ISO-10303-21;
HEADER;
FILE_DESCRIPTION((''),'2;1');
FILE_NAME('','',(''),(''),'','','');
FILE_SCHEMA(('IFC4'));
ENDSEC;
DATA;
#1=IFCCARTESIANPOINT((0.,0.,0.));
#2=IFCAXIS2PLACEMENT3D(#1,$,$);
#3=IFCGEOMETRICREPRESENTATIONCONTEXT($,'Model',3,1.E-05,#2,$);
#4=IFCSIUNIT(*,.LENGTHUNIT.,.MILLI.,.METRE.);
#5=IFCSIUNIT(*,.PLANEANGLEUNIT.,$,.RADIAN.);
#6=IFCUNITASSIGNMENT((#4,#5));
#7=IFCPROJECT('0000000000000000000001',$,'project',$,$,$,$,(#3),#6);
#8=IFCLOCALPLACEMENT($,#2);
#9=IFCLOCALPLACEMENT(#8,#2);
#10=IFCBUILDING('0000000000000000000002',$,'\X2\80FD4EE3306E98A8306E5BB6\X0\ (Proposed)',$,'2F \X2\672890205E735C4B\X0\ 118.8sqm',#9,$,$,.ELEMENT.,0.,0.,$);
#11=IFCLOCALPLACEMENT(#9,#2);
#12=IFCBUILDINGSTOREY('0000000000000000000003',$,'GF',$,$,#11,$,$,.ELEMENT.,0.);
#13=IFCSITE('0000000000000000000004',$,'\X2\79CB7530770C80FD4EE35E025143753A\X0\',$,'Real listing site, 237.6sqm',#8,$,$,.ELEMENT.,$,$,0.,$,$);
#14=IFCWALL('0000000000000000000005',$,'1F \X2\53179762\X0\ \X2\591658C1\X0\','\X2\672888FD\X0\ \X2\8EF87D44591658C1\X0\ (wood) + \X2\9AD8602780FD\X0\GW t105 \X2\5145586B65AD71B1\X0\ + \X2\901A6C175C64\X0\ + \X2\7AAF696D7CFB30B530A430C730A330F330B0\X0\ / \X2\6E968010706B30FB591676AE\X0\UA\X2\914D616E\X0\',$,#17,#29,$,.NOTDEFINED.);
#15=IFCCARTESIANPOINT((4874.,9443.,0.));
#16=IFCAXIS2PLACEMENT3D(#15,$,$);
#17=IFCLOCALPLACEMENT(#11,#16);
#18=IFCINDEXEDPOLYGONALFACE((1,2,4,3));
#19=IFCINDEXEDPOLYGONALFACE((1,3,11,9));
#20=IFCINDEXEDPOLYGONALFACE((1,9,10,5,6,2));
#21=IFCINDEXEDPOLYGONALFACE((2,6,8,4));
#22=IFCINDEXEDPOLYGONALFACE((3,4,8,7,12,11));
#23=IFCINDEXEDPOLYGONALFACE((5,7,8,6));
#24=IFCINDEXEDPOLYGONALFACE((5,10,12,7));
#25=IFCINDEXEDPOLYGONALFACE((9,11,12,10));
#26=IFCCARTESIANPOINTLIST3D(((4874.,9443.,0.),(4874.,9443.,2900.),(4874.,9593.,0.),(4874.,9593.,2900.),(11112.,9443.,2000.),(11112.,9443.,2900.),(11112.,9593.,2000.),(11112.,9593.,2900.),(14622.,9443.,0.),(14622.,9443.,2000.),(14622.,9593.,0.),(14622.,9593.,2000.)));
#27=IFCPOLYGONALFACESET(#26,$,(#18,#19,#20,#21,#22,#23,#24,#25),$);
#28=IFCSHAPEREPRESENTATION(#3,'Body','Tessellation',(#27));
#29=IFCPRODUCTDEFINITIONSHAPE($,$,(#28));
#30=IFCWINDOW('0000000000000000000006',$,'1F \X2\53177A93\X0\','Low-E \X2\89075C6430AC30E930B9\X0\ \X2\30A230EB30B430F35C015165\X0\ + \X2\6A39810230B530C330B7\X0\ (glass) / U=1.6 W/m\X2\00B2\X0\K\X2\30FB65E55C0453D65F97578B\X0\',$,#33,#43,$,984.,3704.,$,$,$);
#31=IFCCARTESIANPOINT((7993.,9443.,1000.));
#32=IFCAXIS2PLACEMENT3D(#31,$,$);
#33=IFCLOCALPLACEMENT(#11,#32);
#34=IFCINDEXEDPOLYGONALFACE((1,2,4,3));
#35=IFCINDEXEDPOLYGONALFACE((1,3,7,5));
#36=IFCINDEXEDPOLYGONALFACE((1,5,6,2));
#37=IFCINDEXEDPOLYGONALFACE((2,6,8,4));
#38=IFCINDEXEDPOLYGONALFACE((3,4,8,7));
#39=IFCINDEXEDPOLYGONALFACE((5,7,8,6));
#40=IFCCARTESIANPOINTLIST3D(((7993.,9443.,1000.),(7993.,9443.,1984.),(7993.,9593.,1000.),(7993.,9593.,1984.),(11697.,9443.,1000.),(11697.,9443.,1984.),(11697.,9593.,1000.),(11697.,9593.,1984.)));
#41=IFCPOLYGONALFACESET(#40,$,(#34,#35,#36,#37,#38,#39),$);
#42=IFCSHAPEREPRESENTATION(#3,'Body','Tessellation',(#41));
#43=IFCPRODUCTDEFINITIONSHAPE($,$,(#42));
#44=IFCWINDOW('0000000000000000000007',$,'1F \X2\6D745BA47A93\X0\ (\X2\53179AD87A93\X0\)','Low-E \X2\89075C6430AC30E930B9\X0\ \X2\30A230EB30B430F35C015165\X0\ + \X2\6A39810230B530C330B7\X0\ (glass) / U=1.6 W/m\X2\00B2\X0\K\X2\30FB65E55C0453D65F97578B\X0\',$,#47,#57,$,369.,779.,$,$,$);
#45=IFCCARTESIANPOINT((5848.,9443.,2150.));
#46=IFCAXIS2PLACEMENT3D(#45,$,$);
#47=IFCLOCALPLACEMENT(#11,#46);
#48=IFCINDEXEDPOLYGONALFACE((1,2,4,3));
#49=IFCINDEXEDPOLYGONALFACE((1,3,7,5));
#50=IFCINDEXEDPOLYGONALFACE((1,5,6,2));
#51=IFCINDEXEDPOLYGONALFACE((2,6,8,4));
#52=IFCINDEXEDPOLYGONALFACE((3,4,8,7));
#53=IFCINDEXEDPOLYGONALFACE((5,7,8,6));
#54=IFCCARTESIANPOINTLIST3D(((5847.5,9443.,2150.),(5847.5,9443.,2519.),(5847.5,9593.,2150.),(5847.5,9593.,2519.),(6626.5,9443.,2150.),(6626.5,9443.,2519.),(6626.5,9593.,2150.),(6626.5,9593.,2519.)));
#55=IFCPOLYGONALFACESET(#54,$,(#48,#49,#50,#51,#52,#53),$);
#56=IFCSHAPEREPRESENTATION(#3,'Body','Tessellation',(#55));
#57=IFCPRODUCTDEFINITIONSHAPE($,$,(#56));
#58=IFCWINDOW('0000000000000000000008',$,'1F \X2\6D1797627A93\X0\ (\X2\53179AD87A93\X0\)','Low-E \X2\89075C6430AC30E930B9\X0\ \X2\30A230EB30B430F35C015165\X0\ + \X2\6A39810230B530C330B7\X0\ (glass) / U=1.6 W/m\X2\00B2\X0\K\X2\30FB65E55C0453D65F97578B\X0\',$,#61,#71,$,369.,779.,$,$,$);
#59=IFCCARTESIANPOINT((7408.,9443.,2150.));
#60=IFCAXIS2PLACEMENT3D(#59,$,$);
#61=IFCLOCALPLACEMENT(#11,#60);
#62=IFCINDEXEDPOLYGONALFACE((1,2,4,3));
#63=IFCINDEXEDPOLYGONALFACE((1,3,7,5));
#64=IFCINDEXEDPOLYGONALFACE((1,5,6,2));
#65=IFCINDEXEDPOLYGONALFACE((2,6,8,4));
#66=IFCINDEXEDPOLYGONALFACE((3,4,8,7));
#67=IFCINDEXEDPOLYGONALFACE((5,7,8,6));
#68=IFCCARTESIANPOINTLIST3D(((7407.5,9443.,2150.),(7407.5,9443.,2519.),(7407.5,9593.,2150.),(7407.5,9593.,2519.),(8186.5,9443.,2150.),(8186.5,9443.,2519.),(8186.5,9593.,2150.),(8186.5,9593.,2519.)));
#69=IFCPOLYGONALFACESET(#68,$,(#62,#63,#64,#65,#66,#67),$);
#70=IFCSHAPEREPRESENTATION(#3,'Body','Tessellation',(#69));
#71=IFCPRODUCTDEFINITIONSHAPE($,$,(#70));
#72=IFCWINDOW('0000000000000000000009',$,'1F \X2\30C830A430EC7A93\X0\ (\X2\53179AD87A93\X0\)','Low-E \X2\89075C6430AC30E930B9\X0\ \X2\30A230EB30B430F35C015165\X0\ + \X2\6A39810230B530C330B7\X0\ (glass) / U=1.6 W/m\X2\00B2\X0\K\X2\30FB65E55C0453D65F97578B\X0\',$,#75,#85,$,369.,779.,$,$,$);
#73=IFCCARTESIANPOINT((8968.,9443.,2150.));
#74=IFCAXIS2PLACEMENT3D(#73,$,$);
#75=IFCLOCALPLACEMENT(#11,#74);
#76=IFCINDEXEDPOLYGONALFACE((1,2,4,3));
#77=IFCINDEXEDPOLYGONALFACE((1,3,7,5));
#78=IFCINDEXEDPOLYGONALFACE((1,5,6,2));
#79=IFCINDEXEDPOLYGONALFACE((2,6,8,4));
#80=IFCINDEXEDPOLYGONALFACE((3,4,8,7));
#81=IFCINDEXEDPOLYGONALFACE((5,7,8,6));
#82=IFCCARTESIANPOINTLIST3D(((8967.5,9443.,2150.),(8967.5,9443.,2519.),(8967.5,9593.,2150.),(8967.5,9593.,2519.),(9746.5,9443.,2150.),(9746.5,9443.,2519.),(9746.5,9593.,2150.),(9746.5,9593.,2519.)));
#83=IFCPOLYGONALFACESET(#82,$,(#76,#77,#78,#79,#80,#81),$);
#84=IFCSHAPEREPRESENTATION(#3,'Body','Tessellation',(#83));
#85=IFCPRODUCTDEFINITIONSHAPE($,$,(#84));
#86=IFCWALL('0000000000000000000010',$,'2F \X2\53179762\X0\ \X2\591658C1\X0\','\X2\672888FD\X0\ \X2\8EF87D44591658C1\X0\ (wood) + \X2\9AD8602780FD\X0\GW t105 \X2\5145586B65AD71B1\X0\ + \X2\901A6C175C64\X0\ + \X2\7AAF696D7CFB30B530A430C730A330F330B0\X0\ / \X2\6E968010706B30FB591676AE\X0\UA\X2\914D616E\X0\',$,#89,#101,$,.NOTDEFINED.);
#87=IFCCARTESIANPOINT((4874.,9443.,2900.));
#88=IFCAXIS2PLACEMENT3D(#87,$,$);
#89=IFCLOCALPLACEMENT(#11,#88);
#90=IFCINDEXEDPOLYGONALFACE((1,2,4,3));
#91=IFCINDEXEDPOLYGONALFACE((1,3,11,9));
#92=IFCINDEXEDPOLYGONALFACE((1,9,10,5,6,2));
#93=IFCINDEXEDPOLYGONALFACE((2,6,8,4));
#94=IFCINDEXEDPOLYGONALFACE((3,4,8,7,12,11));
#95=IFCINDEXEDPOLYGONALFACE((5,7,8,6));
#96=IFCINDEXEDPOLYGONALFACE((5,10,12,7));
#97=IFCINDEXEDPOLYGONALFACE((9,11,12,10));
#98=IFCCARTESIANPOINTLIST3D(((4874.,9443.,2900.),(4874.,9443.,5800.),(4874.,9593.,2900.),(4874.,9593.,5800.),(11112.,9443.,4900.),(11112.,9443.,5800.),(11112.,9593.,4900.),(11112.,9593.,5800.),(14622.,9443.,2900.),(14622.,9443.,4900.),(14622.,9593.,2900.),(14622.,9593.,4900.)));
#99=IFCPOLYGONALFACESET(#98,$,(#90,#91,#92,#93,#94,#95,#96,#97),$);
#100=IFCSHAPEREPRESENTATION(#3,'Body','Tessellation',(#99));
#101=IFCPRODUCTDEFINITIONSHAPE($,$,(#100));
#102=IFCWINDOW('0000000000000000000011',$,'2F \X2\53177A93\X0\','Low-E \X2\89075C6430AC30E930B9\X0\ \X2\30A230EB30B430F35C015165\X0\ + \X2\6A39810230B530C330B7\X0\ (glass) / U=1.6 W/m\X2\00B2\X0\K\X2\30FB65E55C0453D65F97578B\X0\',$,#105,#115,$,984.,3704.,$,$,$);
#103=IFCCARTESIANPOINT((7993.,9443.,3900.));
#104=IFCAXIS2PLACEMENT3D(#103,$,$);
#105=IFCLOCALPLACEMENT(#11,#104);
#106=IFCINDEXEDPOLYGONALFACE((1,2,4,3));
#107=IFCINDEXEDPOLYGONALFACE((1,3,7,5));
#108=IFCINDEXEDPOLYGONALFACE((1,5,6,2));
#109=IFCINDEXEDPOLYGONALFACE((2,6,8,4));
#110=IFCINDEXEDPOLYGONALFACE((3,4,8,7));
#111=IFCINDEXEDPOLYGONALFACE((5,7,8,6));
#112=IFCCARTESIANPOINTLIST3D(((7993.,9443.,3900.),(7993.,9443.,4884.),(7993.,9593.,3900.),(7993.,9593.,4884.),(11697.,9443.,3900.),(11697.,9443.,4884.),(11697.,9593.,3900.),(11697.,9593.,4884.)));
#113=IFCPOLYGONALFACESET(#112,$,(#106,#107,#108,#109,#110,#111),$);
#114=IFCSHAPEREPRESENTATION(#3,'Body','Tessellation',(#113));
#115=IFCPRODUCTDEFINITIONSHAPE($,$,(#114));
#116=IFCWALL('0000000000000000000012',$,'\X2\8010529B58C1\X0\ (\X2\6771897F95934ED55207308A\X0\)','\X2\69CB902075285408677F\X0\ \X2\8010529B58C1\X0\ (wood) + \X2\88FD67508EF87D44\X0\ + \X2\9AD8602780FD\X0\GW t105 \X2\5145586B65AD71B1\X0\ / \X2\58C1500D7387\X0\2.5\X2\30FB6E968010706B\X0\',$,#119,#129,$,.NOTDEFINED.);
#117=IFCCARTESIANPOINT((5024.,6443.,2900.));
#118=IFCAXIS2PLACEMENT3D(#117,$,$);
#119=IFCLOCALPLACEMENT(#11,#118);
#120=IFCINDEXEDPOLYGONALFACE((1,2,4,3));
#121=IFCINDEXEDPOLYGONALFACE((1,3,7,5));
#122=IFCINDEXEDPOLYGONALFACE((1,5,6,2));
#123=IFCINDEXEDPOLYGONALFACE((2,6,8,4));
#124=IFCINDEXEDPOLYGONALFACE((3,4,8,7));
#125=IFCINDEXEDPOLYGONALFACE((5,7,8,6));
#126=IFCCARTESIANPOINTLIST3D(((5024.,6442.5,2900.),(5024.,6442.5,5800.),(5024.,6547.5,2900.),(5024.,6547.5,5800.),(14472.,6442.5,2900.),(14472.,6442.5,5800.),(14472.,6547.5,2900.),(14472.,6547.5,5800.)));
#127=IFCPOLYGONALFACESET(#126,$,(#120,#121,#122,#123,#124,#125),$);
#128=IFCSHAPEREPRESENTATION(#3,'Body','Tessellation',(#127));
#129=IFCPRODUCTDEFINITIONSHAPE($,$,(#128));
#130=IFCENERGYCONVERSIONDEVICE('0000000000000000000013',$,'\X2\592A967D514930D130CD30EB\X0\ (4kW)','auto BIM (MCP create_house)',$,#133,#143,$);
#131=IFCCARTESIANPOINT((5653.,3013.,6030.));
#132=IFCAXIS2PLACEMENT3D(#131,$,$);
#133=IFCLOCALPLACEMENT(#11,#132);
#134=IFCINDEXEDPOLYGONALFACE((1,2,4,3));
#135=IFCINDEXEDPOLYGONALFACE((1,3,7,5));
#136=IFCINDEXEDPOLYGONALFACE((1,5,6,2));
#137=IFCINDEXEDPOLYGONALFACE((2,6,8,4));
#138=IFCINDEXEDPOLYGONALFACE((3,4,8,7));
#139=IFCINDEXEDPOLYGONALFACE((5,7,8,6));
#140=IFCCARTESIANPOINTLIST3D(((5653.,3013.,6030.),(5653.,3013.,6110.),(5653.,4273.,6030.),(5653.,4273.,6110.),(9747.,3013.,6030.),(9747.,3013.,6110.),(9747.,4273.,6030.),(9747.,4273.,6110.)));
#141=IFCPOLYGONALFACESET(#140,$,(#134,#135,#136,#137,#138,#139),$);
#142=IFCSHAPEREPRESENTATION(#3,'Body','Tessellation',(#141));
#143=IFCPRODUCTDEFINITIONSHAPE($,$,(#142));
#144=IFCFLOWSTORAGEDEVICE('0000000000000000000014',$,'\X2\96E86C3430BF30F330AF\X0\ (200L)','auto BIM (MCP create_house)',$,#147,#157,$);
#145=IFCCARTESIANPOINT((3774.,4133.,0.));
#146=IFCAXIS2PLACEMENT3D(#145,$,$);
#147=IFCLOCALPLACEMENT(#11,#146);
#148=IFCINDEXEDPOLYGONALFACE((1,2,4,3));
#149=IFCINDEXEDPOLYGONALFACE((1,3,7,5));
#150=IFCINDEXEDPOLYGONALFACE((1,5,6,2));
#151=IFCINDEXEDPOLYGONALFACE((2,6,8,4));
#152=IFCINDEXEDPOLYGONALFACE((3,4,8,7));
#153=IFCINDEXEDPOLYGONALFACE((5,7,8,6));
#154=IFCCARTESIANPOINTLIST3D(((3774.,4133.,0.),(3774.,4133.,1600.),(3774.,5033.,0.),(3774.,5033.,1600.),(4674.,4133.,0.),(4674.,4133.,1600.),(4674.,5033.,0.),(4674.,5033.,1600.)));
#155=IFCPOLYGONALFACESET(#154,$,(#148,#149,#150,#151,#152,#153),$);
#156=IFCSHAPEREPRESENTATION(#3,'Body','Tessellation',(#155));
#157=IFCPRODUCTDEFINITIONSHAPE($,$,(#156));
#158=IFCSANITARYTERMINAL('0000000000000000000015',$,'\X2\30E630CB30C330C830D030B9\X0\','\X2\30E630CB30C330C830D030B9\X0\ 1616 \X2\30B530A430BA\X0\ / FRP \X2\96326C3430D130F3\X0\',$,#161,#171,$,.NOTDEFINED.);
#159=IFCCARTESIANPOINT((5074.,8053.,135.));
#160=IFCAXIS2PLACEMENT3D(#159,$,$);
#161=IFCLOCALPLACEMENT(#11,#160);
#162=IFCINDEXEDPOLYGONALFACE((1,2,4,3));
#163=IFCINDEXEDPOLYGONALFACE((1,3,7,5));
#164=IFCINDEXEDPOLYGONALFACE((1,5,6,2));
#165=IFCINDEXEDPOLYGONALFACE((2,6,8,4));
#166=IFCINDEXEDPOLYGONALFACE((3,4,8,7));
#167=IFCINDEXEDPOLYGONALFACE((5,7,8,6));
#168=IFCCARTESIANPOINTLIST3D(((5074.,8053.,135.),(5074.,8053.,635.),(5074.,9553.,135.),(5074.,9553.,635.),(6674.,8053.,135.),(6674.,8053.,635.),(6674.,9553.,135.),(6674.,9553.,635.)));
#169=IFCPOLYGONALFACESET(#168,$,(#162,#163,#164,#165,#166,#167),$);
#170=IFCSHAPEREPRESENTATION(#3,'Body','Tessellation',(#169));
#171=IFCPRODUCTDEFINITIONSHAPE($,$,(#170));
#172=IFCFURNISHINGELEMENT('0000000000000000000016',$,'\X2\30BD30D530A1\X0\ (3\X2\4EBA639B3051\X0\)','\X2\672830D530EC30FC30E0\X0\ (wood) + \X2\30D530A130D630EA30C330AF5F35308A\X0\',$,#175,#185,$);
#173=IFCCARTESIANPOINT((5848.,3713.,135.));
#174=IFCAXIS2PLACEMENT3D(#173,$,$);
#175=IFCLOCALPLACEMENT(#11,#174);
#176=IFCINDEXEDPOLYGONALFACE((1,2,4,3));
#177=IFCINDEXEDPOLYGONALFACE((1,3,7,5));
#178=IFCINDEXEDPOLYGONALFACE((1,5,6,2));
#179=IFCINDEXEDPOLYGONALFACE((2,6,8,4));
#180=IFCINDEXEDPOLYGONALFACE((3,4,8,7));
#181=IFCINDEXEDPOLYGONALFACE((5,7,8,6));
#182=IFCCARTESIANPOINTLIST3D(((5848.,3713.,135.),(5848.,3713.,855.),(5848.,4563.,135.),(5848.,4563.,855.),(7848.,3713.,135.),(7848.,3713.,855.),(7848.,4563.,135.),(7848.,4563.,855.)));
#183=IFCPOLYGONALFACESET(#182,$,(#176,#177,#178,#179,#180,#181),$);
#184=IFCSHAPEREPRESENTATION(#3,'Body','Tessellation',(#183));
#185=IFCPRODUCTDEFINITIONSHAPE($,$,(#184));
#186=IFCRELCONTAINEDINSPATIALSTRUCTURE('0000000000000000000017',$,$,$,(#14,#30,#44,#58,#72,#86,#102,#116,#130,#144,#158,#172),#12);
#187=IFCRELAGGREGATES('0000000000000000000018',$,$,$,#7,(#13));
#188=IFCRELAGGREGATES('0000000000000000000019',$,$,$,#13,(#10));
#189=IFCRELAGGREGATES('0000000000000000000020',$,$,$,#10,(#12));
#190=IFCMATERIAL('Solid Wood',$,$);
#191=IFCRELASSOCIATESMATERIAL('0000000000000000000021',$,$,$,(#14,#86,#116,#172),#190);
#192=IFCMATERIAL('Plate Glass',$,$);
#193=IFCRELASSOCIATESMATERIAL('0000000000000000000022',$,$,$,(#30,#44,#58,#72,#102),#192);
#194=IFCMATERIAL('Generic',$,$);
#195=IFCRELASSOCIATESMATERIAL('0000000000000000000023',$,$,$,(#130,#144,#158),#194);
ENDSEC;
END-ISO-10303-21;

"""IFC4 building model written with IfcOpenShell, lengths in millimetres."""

from ifc_helpers import new_model, si_unit, frame, frame_2d, origin, place, context, project, spatial, rectangle, extrude, material, element, fill, save


model = new_model("IFC4")

# Units and contexts
model_context = context("Model", 3, precision=1e-05, world=origin())
ifc_project = project(units=[si_unit("LENGTHUNIT", "METRE", prefix="MILLI"), si_unit("PLANEANGLEUNIT", "RADIAN")], contexts=[model_context])

# Site, building, storey
site_placement = place(None, origin())
site = spatial("IfcSite", under=ifc_project, at=site_placement, Name="秋田県能代市元町", ObjectType="Real listing site, 237.6sqm", CompositionType="ELEMENT", RefElevation=0.0)
building_placement = place(site_placement, origin())
building = spatial("IfcBuilding", under=site, at=building_placement, Name="能代の風の家 (Proposed)", ObjectType="2F 木造平屋 118.8sqm", CompositionType="ELEMENT", ElevationOfRefHeight=0.0, ElevationOfTerrain=0.0)
storey_placement = place(building_placement, origin())
storey = spatial("IfcBuildingStorey", under=building, at=storey_placement, Name="GF", CompositionType="ELEMENT", Elevation=0.0)

# Wall, openings, windows
ifc_material_1 = material(Name="Solid Wood")
wall_1_placement = place(storey_placement, frame((4874.0, 9443.0, 0.0)))
wall_1 = element("IfcWall", 1, at=wall_1_placement, inside=storey, material=ifc_material_1, Name="1F 北面 外壁", Description="木製 軸組外壁 (wood) + 高性能GW t105 充填断熱 + 通気層 + 窯業系サイディング / 準耐火・外皮UA配慮", PredefinedType="NOTDEFINED", context=model_context, shape_type="SweptSolid", body=[
    extrude(rectangle(XDim=9748.0, YDim=150.0, at=frame_2d((4874.0, 75.0))), frame((4874.0, 9443.0, 0.0)), (0.0, 0.0, 1.0), 2900.0),
])
opening_1_placement = place(storey_placement, frame((7993.0, 9443.0, 1000.0)))
opening_1 = element("IfcOpeningElement", 2, at=opening_1_placement, cuts=wall_1, PredefinedType="NOTDEFINED", context=model_context, shape_type="SweptSolid", body=[
    extrude(rectangle(XDim=3704.0, YDim=150.0, at=frame_2d((1852.0, 75.0))), frame((7993.0, 9443.0, 1000.0)), (0.0, 0.0, 1.0), 984.0),
])
opening_2_placement = place(storey_placement, frame((5848.0, 9443.0, 2150.0)))
opening_2 = element("IfcOpeningElement", 3, at=opening_2_placement, cuts=wall_1, PredefinedType="NOTDEFINED", context=model_context, shape_type="SweptSolid", body=[
    extrude(rectangle(XDim=779.0, YDim=150.0, at=frame_2d((389.0, 75.0))), frame((5848.0, 9443.0, 2150.0)), (0.0, 0.0, 1.0), 369.0),
])
opening_3_placement = place(storey_placement, frame((7408.0, 9443.0, 2150.0)))
opening_3 = element("IfcOpeningElement", 4, at=opening_3_placement, cuts=wall_1, PredefinedType="NOTDEFINED", context=model_context, shape_type="SweptSolid", body=[
    extrude(rectangle(XDim=779.0, YDim=150.0, at=frame_2d((389.0, 75.0))), frame((7408.0, 9443.0, 2150.0)), (0.0, 0.0, 1.0), 369.0),
])
opening_4_placement = place(storey_placement, frame((8968.0, 9443.0, 2150.0)))
opening_4 = element("IfcOpeningElement", 5, at=opening_4_placement, cuts=wall_1, PredefinedType="NOTDEFINED", context=model_context, shape_type="SweptSolid", body=[
    extrude(rectangle(XDim=779.0, YDim=150.0, at=frame_2d((389.0, 75.0))), frame((8968.0, 9443.0, 2150.0)), (0.0, 0.0, 1.0), 369.0),
])
ifc_material_2 = material(Name="Plate Glass")
window_1_placement = place(storey_placement, frame((7993.0, 9443.0, 1000.0)))
window_1 = element("IfcWindow", 6, at=window_1_placement, inside=storey, material=ifc_material_2, Name="1F 北窓", Description="Low-E 複層ガラス アルゴン封入 + 樹脂サッシ (glass) / U=1.6 W/m²K・日射取得型", OverallHeight=984.0, OverallWidth=3704.0, context=model_context, shape_type="SweptSolid", body=[
    extrude(rectangle(XDim=3704.0, YDim=150.0, at=frame_2d((1852.0, 75.0))), frame((7993.0, 9443.0, 1000.0)), (0.0, 0.0, 1.0), 984.0),
])
fill(opening_1, window_1)
window_2_placement = place(storey_placement, frame((5848.0, 9443.0, 2150.0)))
window_2 = element("IfcWindow", 7, at=window_2_placement, inside=storey, material=ifc_material_2, Name="1F 浴室窓 (北高窓)", Description="Low-E 複層ガラス アルゴン封入 + 樹脂サッシ (glass) / U=1.6 W/m²K・日射取得型", OverallHeight=369.0, OverallWidth=779.0, context=model_context, shape_type="SweptSolid", body=[
    extrude(rectangle(XDim=779.0, YDim=150.0, at=frame_2d((389.0, 75.0))), frame((5848.0, 9443.0, 2150.0)), (0.0, 0.0, 1.0), 369.0),
])
fill(opening_2, window_2)
window_3_placement = place(storey_placement, frame((7408.0, 9443.0, 2150.0)))
window_3 = element("IfcWindow", 8, at=window_3_placement, inside=storey, material=ifc_material_2, Name="1F 洗面窓 (北高窓)", Description="Low-E 複層ガラス アルゴン封入 + 樹脂サッシ (glass) / U=1.6 W/m²K・日射取得型", OverallHeight=369.0, OverallWidth=779.0, context=model_context, shape_type="SweptSolid", body=[
    extrude(rectangle(XDim=779.0, YDim=150.0, at=frame_2d((389.0, 75.0))), frame((7408.0, 9443.0, 2150.0)), (0.0, 0.0, 1.0), 369.0),
])
fill(opening_3, window_3)
window_4_placement = place(storey_placement, frame((8968.0, 9443.0, 2150.0)))
window_4 = element("IfcWindow", 9, at=window_4_placement, inside=storey, material=ifc_material_2, Name="1F トイレ窓 (北高窓)", Description="Low-E 複層ガラス アルゴン封入 + 樹脂サッシ (glass) / U=1.6 W/m²K・日射取得型", OverallHeight=369.0, OverallWidth=779.0, context=model_context, shape_type="SweptSolid", body=[
    extrude(rectangle(XDim=779.0, YDim=150.0, at=frame_2d((389.0, 75.0))), frame((8968.0, 9443.0, 2150.0)), (0.0, 0.0, 1.0), 369.0),
])
fill(opening_4, window_4)

# Wall, opening, window
wall_2_placement = place(storey_placement, frame((4874.0, 9443.0, 2900.0)))
wall_2 = element("IfcWall", 10, at=wall_2_placement, inside=storey, material=ifc_material_1, Name="2F 北面 外壁", Description="木製 軸組外壁 (wood) + 高性能GW t105 充填断熱 + 通気層 + 窯業系サイディング / 準耐火・外皮UA配慮", PredefinedType="NOTDEFINED", context=model_context, shape_type="SweptSolid", body=[
    extrude(rectangle(XDim=9748.0, YDim=150.0, at=frame_2d((4874.0, 75.0))), frame((4874.0, 9443.0, 2900.0)), (0.0, 0.0, 1.0), 2900.0),
])
opening_5_placement = place(storey_placement, frame((7993.0, 9443.0, 3900.0)))
opening_5 = element("IfcOpeningElement", 11, at=opening_5_placement, cuts=wall_2, PredefinedType="NOTDEFINED", context=model_context, shape_type="SweptSolid", body=[
    extrude(rectangle(XDim=3704.0, YDim=150.0, at=frame_2d((1852.0, 75.0))), frame((7993.0, 9443.0, 3900.0)), (0.0, 0.0, 1.0), 984.0),
])
window_5_placement = place(storey_placement, frame((7993.0, 9443.0, 3900.0)))
window_5 = element("IfcWindow", 12, at=window_5_placement, inside=storey, material=ifc_material_2, Name="2F 北窓", Description="Low-E 複層ガラス アルゴン封入 + 樹脂サッシ (glass) / U=1.6 W/m²K・日射取得型", OverallHeight=984.0, OverallWidth=3704.0, context=model_context, shape_type="SweptSolid", body=[
    extrude(rectangle(XDim=3704.0, YDim=150.0, at=frame_2d((1852.0, 75.0))), frame((7993.0, 9443.0, 3900.0)), (0.0, 0.0, 1.0), 984.0),
])
fill(opening_5, window_5)

# Wall
wall_3_placement = place(storey_placement, frame((5024.0, 6443.0, 2900.0)))
element("IfcWall", 13, at=wall_3_placement, inside=storey, material=ifc_material_1, Name="耐力壁 (東西間仕切り)", Description="構造用合板 耐力壁 (wood) + 製材軸組 + 高性能GW t105 充填断熱 / 壁倍率2.5・準耐火", PredefinedType="NOTDEFINED", context=model_context, shape_type="SweptSolid", body=[
    extrude(rectangle(XDim=9448.0, YDim=105.0, at=frame_2d((4724.0, 52.0))), frame((5024.0, 6443.0, 2900.0)), (0.0, 0.0, 1.0), 2900.0),
])

# Energy conversion device
ifc_material_3 = material(Name="Generic")
energy_conversion_device_placement = place(storey_placement, frame((5653.0, 3013.0, 6030.0)))
element("IfcEnergyConversionDevice", 14, at=energy_conversion_device_placement, inside=storey, material=ifc_material_3, Name="太陽光パネル (4kW)", Description="auto BIM (MCP create_house)", context=model_context, shape_type="SweptSolid", body=[
    extrude(rectangle(XDim=4094.0, YDim=1260.0, at=frame_2d((2047.0, 630.0))), frame((5653.0, 3013.0, 6030.0)), (0.0, 0.0, 1.0), 80.0),
])

# Flow storage device
flow_storage_device_placement = place(storey_placement, frame((3774.0, 4133.0, 0.0)))
element("IfcFlowStorageDevice", 15, at=flow_storage_device_placement, inside=storey, material=ifc_material_3, Name="雨水タンク (200L)", Description="auto BIM (MCP create_house)", context=model_context, shape_type="SweptSolid", body=[
    extrude(rectangle(XDim=900.0, YDim=900.0, at=frame_2d((450.0, 450.0))), frame((3774.0, 4133.0, 0.0)), (0.0, 0.0, 1.0), 1600.0),
])

# Sanitary terminal
sanitary_terminal_placement = place(storey_placement, frame((5074.0, 8053.0, 135.0)))
element("IfcSanitaryTerminal", 16, at=sanitary_terminal_placement, inside=storey, material=ifc_material_3, Name="ユニットバス", Description="ユニットバス 1616 サイズ / FRP 防水パン", PredefinedType="NOTDEFINED", context=model_context, shape_type="SweptSolid", body=[
    extrude(rectangle(XDim=1600.0, YDim=1500.0, at=frame_2d((800.0, 750.0))), frame((5074.0, 8053.0, 135.0)), (0.0, 0.0, 1.0), 500.0),
])

# Furnishing element
furnishing_1_placement = place(storey_placement, frame((5848.0, 3713.0, 135.0)))
element("IfcFurnishingElement", 17, at=furnishing_1_placement, inside=storey, material=ifc_material_1, Name="ソファ (3人掛け)", Description="木フレーム (wood) + ファブリック張り", context=model_context, shape_type="SweptSolid", body=[
    extrude(rectangle(XDim=2000.0, YDim=850.0, at=frame_2d((1000.0, 425.0))), frame((5848.0, 3713.0, 135.0)), (0.0, 0.0, 1.0), 720.0),
])

save(model, "model.ifc")
